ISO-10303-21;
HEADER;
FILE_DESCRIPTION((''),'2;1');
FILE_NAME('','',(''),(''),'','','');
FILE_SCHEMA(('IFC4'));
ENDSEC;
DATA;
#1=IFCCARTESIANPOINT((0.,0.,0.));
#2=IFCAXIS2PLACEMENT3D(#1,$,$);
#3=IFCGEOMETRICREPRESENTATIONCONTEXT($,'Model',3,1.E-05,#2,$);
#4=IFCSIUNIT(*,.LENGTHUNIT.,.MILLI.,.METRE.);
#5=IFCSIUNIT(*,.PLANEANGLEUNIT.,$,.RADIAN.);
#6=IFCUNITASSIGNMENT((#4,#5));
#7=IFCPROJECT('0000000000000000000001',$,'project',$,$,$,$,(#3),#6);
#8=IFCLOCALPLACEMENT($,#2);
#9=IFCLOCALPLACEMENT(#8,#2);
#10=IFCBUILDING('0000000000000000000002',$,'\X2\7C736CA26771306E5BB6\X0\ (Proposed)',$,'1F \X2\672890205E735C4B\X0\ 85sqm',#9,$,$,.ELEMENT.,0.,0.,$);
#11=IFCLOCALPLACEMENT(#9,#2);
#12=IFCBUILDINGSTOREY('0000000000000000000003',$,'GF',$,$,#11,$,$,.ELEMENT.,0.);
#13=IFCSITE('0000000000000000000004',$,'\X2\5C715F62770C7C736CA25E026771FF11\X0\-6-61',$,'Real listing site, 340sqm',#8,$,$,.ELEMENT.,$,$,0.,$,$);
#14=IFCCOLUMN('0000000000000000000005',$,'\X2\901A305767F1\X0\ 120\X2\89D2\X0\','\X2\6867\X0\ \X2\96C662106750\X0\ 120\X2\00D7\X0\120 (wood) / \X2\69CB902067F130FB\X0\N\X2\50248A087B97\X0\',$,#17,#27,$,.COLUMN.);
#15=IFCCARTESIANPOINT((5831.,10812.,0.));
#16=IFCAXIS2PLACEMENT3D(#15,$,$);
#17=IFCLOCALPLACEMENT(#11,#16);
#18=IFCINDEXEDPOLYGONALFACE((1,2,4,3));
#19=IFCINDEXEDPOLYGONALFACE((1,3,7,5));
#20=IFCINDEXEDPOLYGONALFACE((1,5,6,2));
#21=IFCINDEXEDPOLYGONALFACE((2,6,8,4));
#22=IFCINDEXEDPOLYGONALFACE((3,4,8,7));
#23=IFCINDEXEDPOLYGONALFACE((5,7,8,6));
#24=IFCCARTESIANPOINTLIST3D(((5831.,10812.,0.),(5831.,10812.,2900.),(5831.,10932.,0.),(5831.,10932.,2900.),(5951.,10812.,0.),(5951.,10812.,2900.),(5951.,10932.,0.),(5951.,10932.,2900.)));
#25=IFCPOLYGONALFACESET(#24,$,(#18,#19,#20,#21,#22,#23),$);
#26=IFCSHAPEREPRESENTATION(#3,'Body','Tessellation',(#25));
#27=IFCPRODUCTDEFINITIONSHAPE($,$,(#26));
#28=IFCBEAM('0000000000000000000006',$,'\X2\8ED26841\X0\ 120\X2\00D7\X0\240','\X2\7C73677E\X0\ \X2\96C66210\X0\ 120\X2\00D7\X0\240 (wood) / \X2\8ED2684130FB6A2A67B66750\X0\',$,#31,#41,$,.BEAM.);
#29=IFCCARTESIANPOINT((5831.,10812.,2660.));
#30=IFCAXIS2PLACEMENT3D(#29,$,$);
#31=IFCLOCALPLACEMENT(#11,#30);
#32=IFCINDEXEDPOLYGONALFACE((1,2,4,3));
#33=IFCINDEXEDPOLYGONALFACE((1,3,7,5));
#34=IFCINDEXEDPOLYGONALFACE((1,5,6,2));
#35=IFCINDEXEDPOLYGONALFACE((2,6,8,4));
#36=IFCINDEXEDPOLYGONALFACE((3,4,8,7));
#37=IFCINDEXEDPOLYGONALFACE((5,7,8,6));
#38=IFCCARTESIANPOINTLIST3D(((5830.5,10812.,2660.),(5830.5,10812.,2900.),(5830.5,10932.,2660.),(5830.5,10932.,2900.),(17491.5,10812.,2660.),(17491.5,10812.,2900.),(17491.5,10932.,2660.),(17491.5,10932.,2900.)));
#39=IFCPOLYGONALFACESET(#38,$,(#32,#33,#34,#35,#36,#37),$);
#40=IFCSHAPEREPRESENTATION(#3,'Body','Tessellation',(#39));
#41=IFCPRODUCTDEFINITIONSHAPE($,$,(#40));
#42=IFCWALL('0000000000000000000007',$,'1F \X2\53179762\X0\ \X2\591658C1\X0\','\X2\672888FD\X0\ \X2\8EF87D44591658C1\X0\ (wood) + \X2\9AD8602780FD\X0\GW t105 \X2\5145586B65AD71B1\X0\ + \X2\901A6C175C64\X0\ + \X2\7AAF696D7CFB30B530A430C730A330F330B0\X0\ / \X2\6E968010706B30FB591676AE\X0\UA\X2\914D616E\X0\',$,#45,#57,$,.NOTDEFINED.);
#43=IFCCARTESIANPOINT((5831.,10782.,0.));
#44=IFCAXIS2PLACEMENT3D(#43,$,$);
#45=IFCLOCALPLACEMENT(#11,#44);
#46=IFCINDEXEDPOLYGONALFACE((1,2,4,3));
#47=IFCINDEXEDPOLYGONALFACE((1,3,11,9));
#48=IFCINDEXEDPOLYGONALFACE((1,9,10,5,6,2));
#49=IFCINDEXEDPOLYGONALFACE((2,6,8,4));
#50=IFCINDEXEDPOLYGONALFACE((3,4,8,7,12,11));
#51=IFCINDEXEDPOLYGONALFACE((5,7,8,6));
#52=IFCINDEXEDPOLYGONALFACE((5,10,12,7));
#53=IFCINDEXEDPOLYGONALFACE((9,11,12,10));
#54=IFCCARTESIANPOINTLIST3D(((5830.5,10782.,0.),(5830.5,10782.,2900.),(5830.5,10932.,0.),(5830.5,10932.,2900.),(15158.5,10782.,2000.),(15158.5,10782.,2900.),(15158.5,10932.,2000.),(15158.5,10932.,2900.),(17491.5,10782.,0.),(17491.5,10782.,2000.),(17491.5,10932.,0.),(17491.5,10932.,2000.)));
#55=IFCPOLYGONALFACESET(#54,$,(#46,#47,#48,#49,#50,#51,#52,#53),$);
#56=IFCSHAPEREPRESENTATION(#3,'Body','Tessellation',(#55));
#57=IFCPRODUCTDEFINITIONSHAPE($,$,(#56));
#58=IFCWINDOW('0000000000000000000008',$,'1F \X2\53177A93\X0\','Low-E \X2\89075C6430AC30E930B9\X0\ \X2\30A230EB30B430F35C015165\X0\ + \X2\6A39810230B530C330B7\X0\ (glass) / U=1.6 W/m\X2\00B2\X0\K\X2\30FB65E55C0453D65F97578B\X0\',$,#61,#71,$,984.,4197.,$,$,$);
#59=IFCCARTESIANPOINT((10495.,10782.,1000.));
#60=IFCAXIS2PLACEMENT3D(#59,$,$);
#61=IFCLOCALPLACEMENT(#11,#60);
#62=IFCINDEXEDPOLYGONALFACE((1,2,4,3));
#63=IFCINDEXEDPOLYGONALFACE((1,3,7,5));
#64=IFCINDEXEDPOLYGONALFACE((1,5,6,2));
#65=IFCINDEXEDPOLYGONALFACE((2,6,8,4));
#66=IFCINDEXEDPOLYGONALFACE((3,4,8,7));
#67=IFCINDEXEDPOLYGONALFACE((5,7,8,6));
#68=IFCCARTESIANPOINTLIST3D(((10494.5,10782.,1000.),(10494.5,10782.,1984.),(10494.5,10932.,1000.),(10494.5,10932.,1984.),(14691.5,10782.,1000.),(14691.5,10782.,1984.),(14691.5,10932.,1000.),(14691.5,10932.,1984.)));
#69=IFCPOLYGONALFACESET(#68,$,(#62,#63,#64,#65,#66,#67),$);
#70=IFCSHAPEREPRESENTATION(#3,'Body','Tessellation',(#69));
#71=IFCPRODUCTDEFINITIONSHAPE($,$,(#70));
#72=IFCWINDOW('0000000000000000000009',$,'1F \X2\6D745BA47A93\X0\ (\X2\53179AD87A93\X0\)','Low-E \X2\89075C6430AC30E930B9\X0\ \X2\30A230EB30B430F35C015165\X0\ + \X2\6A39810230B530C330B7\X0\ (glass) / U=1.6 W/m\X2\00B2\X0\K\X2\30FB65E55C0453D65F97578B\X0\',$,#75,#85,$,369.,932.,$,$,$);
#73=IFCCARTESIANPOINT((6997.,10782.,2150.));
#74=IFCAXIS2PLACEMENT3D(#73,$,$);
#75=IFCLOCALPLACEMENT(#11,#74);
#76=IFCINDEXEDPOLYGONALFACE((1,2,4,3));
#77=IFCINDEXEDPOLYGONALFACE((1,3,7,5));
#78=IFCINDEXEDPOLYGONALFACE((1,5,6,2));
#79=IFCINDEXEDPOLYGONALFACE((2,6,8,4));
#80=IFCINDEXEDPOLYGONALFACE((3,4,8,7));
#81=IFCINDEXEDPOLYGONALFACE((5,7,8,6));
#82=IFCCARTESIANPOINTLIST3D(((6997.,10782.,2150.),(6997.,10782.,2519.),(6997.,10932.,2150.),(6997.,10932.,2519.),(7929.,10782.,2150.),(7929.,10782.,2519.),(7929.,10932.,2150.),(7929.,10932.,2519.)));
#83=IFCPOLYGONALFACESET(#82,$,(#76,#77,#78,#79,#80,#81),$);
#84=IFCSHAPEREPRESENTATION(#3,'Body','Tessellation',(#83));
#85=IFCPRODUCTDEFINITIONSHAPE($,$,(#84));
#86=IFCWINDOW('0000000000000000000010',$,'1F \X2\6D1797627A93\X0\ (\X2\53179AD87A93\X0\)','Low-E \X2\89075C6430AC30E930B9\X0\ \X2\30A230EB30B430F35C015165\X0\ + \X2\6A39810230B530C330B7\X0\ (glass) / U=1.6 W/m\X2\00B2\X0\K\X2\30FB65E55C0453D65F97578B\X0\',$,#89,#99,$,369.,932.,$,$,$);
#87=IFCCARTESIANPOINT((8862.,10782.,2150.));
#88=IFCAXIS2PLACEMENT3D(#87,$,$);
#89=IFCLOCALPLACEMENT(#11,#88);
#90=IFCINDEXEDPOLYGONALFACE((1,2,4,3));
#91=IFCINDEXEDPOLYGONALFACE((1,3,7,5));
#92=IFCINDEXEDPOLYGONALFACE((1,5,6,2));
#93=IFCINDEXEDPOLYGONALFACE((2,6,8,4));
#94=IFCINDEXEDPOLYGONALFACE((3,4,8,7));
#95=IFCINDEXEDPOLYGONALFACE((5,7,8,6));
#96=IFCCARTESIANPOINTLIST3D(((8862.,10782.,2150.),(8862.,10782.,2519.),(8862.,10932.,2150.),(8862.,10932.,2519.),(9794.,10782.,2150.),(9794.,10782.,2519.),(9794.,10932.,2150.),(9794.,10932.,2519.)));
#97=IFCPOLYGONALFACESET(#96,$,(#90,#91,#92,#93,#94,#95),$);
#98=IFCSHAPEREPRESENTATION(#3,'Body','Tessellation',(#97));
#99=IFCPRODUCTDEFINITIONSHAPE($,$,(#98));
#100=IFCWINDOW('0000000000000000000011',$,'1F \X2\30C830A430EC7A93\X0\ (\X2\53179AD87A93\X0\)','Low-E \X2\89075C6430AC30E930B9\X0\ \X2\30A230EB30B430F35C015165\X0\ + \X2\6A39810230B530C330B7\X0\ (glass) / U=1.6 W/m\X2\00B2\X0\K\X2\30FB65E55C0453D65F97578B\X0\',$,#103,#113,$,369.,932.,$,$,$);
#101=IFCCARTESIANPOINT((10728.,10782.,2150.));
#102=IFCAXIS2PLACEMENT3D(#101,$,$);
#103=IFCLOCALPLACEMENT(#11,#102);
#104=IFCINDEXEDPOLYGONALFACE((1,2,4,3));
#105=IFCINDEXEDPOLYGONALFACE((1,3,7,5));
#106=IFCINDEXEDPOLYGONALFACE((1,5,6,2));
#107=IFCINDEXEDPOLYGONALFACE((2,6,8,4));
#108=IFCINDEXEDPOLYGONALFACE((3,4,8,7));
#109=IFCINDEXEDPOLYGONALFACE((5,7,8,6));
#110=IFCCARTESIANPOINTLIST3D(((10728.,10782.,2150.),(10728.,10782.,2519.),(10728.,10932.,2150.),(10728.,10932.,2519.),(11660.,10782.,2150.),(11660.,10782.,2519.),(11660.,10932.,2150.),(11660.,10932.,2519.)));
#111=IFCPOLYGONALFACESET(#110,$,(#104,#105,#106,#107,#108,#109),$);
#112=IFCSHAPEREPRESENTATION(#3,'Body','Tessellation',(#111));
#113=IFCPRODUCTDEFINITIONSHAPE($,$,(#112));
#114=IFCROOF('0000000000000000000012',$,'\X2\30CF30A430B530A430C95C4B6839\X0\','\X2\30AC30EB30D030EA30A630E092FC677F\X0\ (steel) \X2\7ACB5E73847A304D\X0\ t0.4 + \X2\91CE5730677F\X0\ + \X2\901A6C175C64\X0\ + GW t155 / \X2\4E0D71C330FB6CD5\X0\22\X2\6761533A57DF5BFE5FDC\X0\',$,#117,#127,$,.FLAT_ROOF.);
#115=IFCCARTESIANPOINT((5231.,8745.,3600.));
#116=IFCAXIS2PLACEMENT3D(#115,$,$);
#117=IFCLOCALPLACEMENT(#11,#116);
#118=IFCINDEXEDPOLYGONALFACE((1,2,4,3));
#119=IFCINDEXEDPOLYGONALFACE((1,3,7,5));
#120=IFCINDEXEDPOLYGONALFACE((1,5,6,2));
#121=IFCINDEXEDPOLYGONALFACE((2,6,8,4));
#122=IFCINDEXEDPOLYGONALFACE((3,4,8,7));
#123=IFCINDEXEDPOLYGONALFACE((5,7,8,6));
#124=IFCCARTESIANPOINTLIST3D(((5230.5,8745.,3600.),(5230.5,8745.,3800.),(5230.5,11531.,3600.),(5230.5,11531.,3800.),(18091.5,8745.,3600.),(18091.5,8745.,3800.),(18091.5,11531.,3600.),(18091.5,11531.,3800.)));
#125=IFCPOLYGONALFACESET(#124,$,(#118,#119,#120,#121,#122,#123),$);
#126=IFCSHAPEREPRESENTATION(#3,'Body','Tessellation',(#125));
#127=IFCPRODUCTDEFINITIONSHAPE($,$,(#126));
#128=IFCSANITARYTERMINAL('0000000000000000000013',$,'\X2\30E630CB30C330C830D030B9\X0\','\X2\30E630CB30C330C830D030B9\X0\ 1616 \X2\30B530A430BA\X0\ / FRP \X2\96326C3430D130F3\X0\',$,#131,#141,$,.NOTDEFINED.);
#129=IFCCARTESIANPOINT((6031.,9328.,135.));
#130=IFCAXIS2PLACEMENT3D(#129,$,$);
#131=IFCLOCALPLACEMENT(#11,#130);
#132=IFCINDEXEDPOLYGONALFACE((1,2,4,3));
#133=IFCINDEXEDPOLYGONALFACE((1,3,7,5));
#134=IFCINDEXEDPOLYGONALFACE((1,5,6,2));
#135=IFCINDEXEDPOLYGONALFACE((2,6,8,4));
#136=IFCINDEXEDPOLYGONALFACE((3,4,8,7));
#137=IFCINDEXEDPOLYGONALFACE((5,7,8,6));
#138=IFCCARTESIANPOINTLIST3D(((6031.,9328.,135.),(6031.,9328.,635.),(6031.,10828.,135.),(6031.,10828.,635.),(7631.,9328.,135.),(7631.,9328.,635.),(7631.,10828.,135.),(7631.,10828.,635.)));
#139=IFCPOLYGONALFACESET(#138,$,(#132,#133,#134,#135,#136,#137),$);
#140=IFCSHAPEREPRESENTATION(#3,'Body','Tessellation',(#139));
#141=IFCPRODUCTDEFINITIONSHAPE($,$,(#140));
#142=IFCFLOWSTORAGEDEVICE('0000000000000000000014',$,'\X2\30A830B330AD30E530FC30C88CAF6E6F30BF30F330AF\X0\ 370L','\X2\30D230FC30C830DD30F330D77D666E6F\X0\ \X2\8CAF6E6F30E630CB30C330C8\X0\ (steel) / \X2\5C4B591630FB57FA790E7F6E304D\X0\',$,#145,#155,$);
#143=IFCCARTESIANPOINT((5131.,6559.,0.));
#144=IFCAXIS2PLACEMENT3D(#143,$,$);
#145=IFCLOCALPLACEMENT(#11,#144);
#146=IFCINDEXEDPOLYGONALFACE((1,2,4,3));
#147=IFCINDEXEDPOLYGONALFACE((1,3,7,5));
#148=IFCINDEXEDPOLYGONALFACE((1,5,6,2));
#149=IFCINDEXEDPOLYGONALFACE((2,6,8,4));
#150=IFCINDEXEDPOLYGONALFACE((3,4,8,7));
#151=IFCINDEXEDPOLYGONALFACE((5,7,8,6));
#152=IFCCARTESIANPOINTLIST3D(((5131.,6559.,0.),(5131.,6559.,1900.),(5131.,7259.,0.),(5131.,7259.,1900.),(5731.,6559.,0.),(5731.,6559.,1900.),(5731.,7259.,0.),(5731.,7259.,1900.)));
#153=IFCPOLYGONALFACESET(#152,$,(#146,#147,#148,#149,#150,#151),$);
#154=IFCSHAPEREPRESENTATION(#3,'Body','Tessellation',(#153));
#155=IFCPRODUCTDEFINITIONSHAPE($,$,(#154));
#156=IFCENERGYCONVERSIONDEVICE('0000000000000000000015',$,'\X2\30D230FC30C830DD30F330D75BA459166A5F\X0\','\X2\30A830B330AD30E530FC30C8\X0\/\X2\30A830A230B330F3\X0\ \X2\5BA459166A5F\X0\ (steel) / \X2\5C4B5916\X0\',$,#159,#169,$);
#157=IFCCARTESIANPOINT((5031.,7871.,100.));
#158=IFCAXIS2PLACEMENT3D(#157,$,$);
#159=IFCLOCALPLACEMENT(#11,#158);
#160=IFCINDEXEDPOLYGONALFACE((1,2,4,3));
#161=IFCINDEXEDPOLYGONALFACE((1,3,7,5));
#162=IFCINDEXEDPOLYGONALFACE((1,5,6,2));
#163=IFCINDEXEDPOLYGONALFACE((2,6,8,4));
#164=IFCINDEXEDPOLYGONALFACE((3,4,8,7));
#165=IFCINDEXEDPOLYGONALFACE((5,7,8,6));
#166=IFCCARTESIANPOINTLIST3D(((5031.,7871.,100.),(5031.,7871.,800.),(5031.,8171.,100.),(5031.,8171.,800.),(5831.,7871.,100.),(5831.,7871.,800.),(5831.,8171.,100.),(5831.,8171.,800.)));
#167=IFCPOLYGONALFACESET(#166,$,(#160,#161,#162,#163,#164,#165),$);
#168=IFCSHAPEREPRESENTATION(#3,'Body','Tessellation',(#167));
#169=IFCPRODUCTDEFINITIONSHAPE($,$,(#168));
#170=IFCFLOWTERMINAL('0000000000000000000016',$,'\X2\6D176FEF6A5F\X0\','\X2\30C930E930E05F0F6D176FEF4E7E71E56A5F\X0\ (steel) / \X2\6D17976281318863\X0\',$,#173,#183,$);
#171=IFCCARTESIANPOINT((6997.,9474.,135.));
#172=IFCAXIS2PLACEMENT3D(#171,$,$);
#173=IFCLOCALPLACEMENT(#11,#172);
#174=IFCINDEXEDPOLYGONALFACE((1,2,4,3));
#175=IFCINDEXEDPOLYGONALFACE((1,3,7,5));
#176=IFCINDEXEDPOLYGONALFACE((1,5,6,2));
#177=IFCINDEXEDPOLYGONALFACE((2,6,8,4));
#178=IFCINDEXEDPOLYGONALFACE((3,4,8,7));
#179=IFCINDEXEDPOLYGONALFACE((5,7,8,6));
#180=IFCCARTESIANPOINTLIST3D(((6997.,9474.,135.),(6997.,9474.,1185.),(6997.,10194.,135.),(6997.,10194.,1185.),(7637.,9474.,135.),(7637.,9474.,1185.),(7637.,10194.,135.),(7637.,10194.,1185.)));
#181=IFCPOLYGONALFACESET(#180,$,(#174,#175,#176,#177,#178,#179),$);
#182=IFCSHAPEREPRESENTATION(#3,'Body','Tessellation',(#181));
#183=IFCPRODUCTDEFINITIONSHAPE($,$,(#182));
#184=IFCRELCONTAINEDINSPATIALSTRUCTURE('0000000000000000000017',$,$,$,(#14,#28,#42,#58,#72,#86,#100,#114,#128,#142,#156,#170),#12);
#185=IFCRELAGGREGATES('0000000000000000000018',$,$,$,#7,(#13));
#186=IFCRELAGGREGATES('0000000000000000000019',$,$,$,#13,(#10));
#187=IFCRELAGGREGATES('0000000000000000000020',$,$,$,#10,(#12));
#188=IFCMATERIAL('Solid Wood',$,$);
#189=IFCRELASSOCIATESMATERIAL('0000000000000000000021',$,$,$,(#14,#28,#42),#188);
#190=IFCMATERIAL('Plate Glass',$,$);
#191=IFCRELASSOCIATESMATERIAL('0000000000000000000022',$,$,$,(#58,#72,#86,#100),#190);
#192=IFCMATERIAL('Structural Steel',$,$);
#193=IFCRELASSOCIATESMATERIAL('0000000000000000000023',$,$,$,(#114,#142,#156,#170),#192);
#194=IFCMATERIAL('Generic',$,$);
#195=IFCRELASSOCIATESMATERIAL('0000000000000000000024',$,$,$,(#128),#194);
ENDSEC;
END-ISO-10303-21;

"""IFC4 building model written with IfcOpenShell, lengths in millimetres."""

from ifc_helpers import new_model, si_unit, frame, frame_2d, origin, place, context, project, spatial, rectangle, extrude, material, element, fill, save


model = new_model("IFC4")

# Units and contexts
model_context = context("Model", 3, precision=1e-05, world=origin())
ifc_project = project(units=[si_unit("LENGTHUNIT", "METRE", prefix="MILLI"), si_unit("PLANEANGLEUNIT", "RADIAN")], contexts=[model_context])

# Site, building, storey
site_placement = place(None, origin())
site = spatial("IfcSite", under=ifc_project, at=site_placement, Name="山形県米沢市東１-6-61", ObjectType="Real listing site, 340sqm", CompositionType="ELEMENT", RefElevation=0.0)
building_placement = place(site_placement, origin())
building = spatial("IfcBuilding", under=site, at=building_placement, Name="米沢東の家 (Proposed)", ObjectType="1F 木造平屋 85sqm", CompositionType="ELEMENT", ElevationOfRefHeight=0.0, ElevationOfTerrain=0.0)
storey_placement = place(building_placement, origin())
storey = spatial("IfcBuildingStorey", under=building, at=storey_placement, Name="GF", CompositionType="ELEMENT", Elevation=0.0)

# Column
ifc_material_1 = material(Name="Solid Wood")
column_1_placement = place(storey_placement, frame((5831.0, 10812.0, 0.0)))
element("IfcColumn", 1, at=column_1_placement, inside=storey, material=ifc_material_1, Name="通し柱 120角", Description="桧 集成材 120×120 (wood) / 構造柱・N値計算", PredefinedType="COLUMN", context=model_context, shape_type="SweptSolid", body=[
    extrude(rectangle(XDim=120.0, YDim=120.0, at=frame_2d((60.0, 60.0))), frame((5831.0, 10812.0, 0.0)), (0.0, 0.0, 1.0), 2900.0),
])

# Beam
beam_1_placement = place(storey_placement, frame((5831.0, 10812.0, 2660.0)))
element("IfcBeam", 2, at=beam_1_placement, inside=storey, material=ifc_material_1, Name="軒桁 120×240", Description="米松 集成 120×240 (wood) / 軒桁・横架材", PredefinedType="BEAM", context=model_context, shape_type="SweptSolid", body=[
    extrude(rectangle(XDim=11661.0, YDim=120.0, at=frame_2d((5830.0, 60.0))), frame((5831.0, 10812.0, 2660.0)), (0.0, 0.0, 1.0), 240.0),
])

# Wall, openings, windows
wall_1_placement = place(storey_placement, frame((5831.0, 10782.0, 0.0)))
wall_1 = element("IfcWall", 3, at=wall_1_placement, inside=storey, material=ifc_material_1, Name="1F 北面 外壁", Description="木製 軸組外壁 (wood) + 高性能GW t105 充填断熱 + 通気層 + 窯業系サイディング / 準耐火・外皮UA配慮", PredefinedType="NOTDEFINED", context=model_context, shape_type="SweptSolid", body=[
    extrude(rectangle(XDim=11661.0, YDim=150.0, at=frame_2d((5830.0, 75.0))), frame((5831.0, 10782.0, 0.0)), (0.0, 0.0, 1.0), 2900.0),
])
opening_1_placement = place(storey_placement, frame((10495.0, 10782.0, 1000.0)))
opening_1 = element("IfcOpeningElement", 4, at=opening_1_placement, cuts=wall_1, PredefinedType="NOTDEFINED", context=model_context, shape_type="SweptSolid", body=[
    extrude(rectangle(XDim=4197.0, YDim=150.0, at=frame_2d((2098.0, 75.0))), frame((10495.0, 10782.0, 1000.0)), (0.0, 0.0, 1.0), 984.0),
])
opening_2_placement = place(storey_placement, frame((6997.0, 10782.0, 2150.0)))
opening_2 = element("IfcOpeningElement", 5, at=opening_2_placement, cuts=wall_1, PredefinedType="NOTDEFINED", context=model_context, shape_type="SweptSolid", body=[
    extrude(rectangle(XDim=932.0, YDim=150.0, at=frame_2d((466.0, 75.0))), frame((6997.0, 10782.0, 2150.0)), (0.0, 0.0, 1.0), 369.0),
])
opening_3_placement = place(storey_placement, frame((8862.0, 10782.0, 2150.0)))
opening_3 = element("IfcOpeningElement", 6, at=opening_3_placement, cuts=wall_1, PredefinedType="NOTDEFINED", context=model_context, shape_type="SweptSolid", body=[
    extrude(rectangle(XDim=932.0, YDim=150.0, at=frame_2d((466.0, 75.0))), frame((8862.0, 10782.0, 2150.0)), (0.0, 0.0, 1.0), 369.0),
])
opening_4_placement = place(storey_placement, frame((10728.0, 10782.0, 2150.0)))
opening_4 = element("IfcOpeningElement", 7, at=opening_4_placement, cuts=wall_1, PredefinedType="NOTDEFINED", context=model_context, shape_type="SweptSolid", body=[
    extrude(rectangle(XDim=932.0, YDim=150.0, at=frame_2d((466.0, 75.0))), frame((10728.0, 10782.0, 2150.0)), (0.0, 0.0, 1.0), 369.0),
])
ifc_material_2 = material(Name="Plate Glass")
window_1_placement = place(storey_placement, frame((10495.0, 10782.0, 1000.0)))
window_1 = element("IfcWindow", 8, at=window_1_placement, inside=storey, material=ifc_material_2, Name="1F 北窓", Description="Low-E 複層ガラス アルゴン封入 + 樹脂サッシ (glass) / U=1.6 W/m²K・日射取得型", OverallHeight=984.0, OverallWidth=4197.0, context=model_context, shape_type="SweptSolid", body=[
    extrude(rectangle(XDim=4197.0, YDim=150.0, at=frame_2d((2098.0, 75.0))), frame((10495.0, 10782.0, 1000.0)), (0.0, 0.0, 1.0), 984.0),
])
fill(opening_1, window_1)
window_2_placement = place(storey_placement, frame((6997.0, 10782.0, 2150.0)))
window_2 = element("IfcWindow", 9, at=window_2_placement, inside=storey, material=ifc_material_2, Name="1F 浴室窓 (北高窓)", Description="Low-E 複層ガラス アルゴン封入 + 樹脂サッシ (glass) / U=1.6 W/m²K・日射取得型", OverallHeight=369.0, OverallWidth=932.0, context=model_context, shape_type="SweptSolid", body=[
    extrude(rectangle(XDim=932.0, YDim=150.0, at=frame_2d((466.0, 75.0))), frame((6997.0, 10782.0, 2150.0)), (0.0, 0.0, 1.0), 369.0),
])
fill(opening_2, window_2)
window_3_placement = place(storey_placement, frame((8862.0, 10782.0, 2150.0)))
window_3 = element("IfcWindow", 10, at=window_3_placement, inside=storey, material=ifc_material_2, Name="1F 洗面窓 (北高窓)", Description="Low-E 複層ガラス アルゴン封入 + 樹脂サッシ (glass) / U=1.6 W/m²K・日射取得型", OverallHeight=369.0, OverallWidth=932.0, context=model_context, shape_type="SweptSolid", body=[
    extrude(rectangle(XDim=932.0, YDim=150.0, at=frame_2d((466.0, 75.0))), frame((8862.0, 10782.0, 2150.0)), (0.0, 0.0, 1.0), 369.0),
])
fill(opening_3, window_3)
window_4_placement = place(storey_placement, frame((10728.0, 10782.0, 2150.0)))
window_4 = element("IfcWindow", 11, at=window_4_placement, inside=storey, material=ifc_material_2, Name="1F トイレ窓 (北高窓)", Description="Low-E 複層ガラス アルゴン封入 + 樹脂サッシ (glass) / U=1.6 W/m²K・日射取得型", OverallHeight=369.0, OverallWidth=932.0, context=model_context, shape_type="SweptSolid", body=[
    extrude(rectangle(XDim=932.0, YDim=150.0, at=frame_2d((466.0, 75.0))), frame((10728.0, 10782.0, 2150.0)), (0.0, 0.0, 1.0), 369.0),
])
fill(opening_4, window_4)

# Roof
ifc_material_3 = material(Name="Structural Steel")
roof_placement = place(storey_placement, frame((5231.0, 8745.0, 3600.0)))
element("IfcRoof", 12, at=roof_placement, inside=storey, material=ifc_material_3, Name="ハイサイド屋根", Description="ガルバリウム鋼板 (steel) 立平葺き t0.4 + 野地板 + 通気層 + GW t155 / 不燃・法22条区域対応", PredefinedType="FLAT_ROOF", context=model_context, shape_type="SweptSolid", body=[
    extrude(rectangle(XDim=12861.0, YDim=2786.0, at=frame_2d((6430.0, 1393.0))), frame((5231.0, 8745.0, 3600.0)), (0.0, 0.0, 1.0), 200.0),
])

# Sanitary terminal
ifc_material_4 = material(Name="Generic")
sanitary_terminal_placement = place(storey_placement, frame((6031.0, 9328.0, 135.0)))
element("IfcSanitaryTerminal", 13, at=sanitary_terminal_placement, inside=storey, material=ifc_material_4, Name="ユニットバス", Description="ユニットバス 1616 サイズ / FRP 防水パン", PredefinedType="NOTDEFINED", context=model_context, shape_type="SweptSolid", body=[
    extrude(rectangle(XDim=1600.0, YDim=1500.0, at=frame_2d((800.0, 750.0))), frame((6031.0, 9328.0, 135.0)), (0.0, 0.0, 1.0), 500.0),
])

# Flow storage device
flow_storage_device_placement = place(storey_placement, frame((5131.0, 6559.0, 0.0)))
element("IfcFlowStorageDevice", 14, at=flow_storage_device_placement, inside=storey, material=ifc_material_3, Name="エコキュート貯湯タンク 370L", Description="ヒートポンプ給湯 貯湯ユニット (steel) / 屋外・基礎置き", context=model_context, shape_type="SweptSolid", body=[
    extrude(rectangle(XDim=600.0, YDim=700.0, at=frame_2d((300.0, 350.0))), frame((5131.0, 6559.0, 0.0)), (0.0, 0.0, 1.0), 1900.0),
])

# Energy conversion device
energy_conversion_device_placement = place(storey_placement, frame((5031.0, 7871.0, 100.0)))
element("IfcEnergyConversionDevice", 15, at=energy_conversion_device_placement, inside=storey, material=ifc_material_3, Name="ヒートポンプ室外機", Description="エコキュート/エアコン 室外機 (steel) / 屋外", context=model_context, shape_type="SweptSolid", body=[
    extrude(rectangle(XDim=800.0, YDim=300.0, at=frame_2d((400.0, 150.0))), frame((5031.0, 7871.0, 100.0)), (0.0, 0.0, 1.0), 700.0),
])

# Flow terminal
flow_terminal_placement = place(storey_placement, frame((6997.0, 9474.0, 135.0)))
element("IfcFlowTerminal", 16, at=flow_terminal_placement, inside=storey, material=ifc_material_3, Name="洗濯機", Description="ドラム式洗濯乾燥機 (steel) / 洗面脱衣", context=model_context, shape_type="SweptSolid", body=[
    extrude(rectangle(XDim=640.0, YDim=720.0, at=frame_2d((320.0, 360.0))), frame((6997.0, 9474.0, 135.0)), (0.0, 0.0, 1.0), 1050.0),
])

save(model, "model.ifc")
